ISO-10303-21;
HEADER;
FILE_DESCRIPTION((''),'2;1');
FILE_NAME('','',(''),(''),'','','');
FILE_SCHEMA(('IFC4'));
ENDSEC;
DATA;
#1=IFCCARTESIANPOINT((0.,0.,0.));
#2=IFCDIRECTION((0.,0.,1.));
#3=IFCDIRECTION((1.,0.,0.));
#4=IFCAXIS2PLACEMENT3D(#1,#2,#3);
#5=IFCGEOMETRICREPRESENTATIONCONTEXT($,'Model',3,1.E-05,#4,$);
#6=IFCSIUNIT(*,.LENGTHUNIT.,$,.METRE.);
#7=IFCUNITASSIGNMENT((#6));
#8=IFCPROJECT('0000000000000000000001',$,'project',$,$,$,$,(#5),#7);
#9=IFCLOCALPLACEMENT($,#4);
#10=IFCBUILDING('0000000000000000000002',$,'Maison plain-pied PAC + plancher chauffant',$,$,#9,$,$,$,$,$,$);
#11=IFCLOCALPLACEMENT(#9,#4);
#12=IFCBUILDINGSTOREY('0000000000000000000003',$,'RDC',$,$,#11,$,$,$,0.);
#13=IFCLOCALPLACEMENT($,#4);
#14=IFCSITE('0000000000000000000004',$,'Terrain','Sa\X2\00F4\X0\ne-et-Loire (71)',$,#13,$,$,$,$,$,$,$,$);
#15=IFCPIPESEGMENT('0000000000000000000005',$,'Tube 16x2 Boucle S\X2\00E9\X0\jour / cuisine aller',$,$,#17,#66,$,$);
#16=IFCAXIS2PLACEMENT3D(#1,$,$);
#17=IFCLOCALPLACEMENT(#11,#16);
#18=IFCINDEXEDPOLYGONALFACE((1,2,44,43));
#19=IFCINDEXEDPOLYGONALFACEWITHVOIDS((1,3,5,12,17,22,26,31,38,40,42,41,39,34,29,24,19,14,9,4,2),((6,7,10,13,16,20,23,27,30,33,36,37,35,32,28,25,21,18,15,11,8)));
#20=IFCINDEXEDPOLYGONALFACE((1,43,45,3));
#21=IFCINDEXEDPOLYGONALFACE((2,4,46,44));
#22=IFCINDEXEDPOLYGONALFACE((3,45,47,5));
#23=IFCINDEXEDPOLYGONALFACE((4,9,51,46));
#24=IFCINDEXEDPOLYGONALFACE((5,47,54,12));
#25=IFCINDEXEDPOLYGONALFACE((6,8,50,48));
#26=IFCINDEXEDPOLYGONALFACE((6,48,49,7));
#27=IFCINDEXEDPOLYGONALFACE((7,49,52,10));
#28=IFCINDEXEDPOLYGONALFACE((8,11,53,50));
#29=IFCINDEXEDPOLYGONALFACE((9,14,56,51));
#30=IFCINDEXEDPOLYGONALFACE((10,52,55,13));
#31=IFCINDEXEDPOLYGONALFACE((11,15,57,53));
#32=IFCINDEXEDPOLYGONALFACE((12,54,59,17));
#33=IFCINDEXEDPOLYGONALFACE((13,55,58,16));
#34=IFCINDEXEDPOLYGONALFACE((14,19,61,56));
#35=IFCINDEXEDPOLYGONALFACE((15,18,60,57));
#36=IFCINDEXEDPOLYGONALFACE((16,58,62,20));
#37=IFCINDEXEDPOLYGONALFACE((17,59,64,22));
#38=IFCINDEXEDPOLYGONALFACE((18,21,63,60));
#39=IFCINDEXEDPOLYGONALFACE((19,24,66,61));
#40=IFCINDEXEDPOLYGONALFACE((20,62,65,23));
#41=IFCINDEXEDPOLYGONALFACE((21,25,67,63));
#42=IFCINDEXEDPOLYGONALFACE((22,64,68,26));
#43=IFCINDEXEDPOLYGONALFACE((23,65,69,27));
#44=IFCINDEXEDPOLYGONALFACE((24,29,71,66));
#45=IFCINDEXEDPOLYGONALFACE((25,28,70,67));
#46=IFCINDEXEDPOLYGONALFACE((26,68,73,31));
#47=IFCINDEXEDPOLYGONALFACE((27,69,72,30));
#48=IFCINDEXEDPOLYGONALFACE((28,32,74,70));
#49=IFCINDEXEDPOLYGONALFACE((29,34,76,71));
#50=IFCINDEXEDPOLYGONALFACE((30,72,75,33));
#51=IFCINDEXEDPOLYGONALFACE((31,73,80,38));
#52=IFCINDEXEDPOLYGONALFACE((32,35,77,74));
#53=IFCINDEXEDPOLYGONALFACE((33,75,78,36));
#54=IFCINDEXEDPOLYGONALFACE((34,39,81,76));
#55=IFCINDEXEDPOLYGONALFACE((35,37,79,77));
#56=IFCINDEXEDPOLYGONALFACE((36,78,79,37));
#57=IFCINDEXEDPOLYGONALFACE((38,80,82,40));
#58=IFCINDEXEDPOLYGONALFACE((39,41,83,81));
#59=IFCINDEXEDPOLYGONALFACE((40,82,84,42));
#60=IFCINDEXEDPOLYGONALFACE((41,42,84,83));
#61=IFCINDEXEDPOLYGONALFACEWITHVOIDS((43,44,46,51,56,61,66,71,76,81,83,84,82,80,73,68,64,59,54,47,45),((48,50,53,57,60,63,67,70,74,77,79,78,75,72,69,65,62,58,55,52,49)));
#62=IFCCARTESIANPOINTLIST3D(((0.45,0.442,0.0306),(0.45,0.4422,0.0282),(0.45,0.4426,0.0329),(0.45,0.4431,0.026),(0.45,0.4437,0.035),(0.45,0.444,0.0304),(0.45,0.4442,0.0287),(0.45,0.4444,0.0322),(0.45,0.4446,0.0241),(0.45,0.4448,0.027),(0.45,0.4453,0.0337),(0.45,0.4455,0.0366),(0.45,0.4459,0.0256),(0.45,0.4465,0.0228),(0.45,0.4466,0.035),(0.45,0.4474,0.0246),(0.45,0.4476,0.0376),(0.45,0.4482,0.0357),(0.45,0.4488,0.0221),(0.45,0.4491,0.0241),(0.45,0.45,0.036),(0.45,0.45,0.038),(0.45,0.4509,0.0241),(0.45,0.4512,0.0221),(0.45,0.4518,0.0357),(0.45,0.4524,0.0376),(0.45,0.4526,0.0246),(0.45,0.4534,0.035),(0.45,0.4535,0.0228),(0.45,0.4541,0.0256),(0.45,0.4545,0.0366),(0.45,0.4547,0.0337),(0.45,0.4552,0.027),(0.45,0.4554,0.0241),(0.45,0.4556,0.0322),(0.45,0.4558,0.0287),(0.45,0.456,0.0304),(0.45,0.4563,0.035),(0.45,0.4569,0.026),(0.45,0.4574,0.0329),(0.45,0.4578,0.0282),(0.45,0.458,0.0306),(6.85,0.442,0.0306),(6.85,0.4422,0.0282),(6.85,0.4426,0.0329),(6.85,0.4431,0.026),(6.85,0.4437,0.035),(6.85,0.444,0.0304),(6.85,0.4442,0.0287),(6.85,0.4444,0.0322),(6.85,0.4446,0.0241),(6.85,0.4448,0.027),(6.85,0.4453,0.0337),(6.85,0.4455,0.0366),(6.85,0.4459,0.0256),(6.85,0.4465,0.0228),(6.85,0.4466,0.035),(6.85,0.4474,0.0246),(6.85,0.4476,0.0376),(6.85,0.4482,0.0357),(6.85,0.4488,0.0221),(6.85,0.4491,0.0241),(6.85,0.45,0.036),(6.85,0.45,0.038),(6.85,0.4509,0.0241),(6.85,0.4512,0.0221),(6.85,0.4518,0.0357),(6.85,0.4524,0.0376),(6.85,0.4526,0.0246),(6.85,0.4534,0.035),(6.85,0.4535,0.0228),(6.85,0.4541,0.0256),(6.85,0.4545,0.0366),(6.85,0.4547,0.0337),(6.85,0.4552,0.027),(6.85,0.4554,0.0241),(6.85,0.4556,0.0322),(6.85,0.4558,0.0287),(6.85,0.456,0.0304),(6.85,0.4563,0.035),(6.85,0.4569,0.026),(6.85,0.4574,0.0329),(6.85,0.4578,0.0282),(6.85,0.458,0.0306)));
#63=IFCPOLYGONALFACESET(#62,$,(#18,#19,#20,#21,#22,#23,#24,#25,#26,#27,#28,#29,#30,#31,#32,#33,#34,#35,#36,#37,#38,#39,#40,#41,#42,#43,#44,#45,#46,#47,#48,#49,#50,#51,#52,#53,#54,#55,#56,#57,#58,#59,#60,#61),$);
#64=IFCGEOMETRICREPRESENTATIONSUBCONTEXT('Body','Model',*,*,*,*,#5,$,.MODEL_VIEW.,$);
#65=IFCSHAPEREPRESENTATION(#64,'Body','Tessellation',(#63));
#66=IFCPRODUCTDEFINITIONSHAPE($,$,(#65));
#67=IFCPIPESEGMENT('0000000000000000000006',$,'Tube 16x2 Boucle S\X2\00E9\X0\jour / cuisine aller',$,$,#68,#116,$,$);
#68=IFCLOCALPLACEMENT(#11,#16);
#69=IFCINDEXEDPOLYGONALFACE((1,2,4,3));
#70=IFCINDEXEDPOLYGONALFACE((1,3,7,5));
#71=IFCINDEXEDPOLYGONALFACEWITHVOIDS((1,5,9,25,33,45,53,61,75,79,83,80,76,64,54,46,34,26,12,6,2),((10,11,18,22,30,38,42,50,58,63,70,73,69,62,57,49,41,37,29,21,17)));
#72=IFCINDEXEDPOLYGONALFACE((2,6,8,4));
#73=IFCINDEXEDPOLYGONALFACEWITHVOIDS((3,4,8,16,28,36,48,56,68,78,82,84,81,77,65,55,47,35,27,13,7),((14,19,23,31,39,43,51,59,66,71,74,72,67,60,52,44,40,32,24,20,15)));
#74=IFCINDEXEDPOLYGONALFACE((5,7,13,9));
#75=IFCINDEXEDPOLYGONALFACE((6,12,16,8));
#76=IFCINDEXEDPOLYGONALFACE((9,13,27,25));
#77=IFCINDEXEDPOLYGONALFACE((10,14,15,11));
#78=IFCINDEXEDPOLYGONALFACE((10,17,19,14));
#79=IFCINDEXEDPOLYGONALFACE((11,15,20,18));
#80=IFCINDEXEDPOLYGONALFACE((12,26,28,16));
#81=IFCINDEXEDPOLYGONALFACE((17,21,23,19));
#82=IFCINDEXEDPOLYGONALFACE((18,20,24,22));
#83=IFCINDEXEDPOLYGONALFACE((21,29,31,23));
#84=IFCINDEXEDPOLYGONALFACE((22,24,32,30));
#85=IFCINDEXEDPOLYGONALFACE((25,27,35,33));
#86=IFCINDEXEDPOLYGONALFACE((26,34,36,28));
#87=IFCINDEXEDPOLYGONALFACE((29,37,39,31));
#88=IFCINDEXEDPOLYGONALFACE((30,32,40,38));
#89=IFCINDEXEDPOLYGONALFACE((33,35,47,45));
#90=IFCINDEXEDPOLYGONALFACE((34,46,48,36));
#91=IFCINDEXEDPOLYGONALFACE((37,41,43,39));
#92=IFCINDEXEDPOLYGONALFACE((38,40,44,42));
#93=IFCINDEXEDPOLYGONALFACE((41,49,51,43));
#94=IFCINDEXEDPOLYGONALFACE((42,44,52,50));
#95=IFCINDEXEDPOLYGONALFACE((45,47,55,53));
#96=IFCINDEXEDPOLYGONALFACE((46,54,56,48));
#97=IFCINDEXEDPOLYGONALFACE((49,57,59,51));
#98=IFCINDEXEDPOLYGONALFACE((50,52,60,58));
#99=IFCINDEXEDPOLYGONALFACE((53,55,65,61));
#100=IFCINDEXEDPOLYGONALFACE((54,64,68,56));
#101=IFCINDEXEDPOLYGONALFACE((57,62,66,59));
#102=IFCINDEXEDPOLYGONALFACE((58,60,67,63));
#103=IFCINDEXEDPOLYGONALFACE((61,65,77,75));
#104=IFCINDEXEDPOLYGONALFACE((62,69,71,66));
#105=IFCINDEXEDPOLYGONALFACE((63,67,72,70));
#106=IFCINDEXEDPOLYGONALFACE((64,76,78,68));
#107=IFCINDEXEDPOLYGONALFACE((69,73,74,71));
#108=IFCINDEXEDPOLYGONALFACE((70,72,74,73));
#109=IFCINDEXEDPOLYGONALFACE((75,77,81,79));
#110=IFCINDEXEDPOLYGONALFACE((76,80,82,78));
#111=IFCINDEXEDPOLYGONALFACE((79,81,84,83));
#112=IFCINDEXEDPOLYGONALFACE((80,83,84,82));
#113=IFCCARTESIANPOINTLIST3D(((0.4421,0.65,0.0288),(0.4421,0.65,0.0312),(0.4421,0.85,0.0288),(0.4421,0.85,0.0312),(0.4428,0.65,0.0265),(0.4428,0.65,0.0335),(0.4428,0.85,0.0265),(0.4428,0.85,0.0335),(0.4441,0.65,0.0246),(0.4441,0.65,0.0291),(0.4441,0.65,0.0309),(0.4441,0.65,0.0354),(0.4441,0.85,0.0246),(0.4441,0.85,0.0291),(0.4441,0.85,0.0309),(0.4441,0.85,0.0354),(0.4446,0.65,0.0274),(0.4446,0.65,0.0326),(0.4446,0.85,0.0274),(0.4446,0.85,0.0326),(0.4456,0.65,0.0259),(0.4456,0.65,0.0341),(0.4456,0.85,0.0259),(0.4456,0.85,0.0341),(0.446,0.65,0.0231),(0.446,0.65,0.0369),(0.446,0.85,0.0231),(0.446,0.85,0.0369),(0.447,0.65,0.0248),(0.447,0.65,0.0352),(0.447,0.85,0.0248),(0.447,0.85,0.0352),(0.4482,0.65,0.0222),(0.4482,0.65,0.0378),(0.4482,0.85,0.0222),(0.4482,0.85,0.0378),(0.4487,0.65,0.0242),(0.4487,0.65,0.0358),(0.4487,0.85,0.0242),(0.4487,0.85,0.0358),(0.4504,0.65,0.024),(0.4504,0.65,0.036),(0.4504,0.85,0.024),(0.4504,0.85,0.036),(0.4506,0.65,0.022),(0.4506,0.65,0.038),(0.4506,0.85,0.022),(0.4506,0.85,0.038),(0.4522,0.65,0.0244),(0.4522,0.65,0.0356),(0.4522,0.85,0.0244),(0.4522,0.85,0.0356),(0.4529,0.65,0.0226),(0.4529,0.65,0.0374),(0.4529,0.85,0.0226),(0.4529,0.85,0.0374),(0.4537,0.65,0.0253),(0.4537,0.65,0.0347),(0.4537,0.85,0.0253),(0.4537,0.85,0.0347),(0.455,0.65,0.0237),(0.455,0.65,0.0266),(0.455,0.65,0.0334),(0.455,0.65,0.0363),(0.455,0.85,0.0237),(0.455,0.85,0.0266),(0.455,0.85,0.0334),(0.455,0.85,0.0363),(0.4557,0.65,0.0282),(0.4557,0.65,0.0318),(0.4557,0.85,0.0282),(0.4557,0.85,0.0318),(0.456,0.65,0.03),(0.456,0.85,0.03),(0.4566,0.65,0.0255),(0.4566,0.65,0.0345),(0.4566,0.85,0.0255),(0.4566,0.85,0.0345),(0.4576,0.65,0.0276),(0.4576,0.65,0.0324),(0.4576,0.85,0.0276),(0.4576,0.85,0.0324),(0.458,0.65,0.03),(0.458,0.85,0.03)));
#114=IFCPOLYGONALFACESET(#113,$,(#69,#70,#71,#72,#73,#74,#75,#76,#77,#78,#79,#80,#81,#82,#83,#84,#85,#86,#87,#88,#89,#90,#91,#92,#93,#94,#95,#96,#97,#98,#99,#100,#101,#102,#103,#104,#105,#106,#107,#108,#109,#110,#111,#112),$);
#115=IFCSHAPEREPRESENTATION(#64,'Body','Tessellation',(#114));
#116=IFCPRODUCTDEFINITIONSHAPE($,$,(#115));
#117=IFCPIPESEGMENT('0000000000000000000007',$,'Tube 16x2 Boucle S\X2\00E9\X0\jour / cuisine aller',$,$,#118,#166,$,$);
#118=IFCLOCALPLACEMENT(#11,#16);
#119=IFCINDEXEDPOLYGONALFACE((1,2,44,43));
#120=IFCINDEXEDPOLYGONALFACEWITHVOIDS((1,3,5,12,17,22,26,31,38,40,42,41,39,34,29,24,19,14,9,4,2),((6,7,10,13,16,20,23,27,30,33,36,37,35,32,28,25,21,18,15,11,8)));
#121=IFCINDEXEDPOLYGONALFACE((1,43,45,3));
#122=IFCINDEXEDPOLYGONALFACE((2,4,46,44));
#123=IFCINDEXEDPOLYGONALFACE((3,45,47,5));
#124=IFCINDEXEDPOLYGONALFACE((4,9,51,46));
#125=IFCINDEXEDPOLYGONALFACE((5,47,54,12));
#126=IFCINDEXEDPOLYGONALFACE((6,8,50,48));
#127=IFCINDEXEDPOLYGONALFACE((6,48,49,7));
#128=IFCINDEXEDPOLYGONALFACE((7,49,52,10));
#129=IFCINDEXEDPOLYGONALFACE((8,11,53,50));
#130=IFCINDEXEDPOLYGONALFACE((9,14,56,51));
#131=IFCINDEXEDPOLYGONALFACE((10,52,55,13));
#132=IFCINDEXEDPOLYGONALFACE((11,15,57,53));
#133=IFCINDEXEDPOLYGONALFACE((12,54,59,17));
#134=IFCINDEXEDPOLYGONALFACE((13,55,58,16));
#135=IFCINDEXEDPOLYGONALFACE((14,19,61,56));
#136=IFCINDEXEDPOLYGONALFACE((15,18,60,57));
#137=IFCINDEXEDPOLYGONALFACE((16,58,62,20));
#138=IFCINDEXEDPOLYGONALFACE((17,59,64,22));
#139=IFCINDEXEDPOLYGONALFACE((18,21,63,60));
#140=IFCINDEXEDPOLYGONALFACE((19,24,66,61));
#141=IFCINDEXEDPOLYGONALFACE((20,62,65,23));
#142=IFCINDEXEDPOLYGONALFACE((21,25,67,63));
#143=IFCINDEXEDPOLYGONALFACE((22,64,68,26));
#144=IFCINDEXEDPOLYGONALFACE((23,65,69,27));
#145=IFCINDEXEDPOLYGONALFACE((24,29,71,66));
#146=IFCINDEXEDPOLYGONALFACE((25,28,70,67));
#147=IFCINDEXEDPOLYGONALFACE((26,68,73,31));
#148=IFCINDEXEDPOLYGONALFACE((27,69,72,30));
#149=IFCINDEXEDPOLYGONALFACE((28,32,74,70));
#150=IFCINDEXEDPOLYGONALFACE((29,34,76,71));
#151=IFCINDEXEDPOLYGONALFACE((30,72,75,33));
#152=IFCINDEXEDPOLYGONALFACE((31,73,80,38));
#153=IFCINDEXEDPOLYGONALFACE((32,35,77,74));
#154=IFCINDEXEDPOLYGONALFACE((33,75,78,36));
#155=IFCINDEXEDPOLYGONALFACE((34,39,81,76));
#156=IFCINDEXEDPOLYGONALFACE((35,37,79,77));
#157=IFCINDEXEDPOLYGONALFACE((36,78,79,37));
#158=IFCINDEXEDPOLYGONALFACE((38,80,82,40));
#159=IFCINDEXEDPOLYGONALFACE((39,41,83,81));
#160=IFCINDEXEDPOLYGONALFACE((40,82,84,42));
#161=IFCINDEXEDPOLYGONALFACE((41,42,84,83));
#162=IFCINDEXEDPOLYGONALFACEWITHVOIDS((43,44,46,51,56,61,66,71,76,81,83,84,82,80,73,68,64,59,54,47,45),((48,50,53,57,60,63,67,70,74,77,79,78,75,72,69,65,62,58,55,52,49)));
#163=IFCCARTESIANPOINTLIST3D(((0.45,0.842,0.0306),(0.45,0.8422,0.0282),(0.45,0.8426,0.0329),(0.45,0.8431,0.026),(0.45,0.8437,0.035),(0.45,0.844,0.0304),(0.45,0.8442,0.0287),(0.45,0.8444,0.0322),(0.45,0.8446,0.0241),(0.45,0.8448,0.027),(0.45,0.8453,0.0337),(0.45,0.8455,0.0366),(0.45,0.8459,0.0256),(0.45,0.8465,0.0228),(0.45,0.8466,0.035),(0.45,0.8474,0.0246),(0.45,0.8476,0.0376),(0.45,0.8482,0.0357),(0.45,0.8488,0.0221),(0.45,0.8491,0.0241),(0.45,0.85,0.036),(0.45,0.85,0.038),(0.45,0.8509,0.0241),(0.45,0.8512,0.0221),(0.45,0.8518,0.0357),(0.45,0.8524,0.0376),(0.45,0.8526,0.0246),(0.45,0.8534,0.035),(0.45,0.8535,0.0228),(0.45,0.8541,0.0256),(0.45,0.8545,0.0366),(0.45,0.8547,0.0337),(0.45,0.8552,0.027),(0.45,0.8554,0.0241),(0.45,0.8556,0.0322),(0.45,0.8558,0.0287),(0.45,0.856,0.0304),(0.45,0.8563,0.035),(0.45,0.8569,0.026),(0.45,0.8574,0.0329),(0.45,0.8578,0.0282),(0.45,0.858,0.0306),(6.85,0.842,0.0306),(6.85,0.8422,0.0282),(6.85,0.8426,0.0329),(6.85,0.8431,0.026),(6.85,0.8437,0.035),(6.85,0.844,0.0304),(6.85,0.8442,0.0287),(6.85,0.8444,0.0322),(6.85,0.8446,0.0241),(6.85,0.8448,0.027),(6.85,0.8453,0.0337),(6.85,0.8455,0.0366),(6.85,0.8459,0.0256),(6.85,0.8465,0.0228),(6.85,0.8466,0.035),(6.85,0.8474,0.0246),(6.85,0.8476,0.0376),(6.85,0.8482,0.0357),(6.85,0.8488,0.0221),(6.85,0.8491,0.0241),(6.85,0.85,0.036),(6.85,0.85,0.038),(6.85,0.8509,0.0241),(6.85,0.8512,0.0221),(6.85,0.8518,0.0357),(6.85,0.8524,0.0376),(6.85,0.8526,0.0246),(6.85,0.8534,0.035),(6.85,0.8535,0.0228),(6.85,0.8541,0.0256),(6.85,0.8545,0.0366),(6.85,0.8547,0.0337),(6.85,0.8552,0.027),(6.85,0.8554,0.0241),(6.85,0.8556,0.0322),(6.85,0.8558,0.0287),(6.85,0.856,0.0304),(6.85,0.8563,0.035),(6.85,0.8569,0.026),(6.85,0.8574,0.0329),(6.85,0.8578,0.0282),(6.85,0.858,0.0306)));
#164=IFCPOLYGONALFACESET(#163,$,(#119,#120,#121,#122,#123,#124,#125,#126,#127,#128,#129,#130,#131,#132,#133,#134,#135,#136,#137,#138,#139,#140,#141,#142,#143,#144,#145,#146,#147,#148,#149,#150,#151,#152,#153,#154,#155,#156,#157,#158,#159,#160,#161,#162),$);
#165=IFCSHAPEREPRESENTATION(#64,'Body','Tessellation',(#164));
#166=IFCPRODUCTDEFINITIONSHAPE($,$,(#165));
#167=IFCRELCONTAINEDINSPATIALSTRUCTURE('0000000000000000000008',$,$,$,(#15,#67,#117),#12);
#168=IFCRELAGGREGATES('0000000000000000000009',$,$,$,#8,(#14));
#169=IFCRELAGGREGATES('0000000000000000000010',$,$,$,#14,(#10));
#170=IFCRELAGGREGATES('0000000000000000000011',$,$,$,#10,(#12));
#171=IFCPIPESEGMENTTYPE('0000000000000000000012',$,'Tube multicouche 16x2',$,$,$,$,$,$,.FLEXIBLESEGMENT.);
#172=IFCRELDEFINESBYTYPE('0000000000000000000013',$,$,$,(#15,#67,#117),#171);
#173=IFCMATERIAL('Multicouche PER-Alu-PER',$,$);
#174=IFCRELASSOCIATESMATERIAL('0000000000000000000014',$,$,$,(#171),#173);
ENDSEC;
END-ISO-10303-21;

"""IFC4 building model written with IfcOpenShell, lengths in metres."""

from ifc_helpers import new_model, si_unit, frame, origin_with_axes, place, context, subcontext, project, spatial, hollow_circle, extrude, material, type_object, element, save


model = new_model("IFC4")

# Units and contexts
model_context = context("Model", 3, precision=1e-05, world=origin_with_axes())
body_context = subcontext(model_context, "Body", "Model", "MODEL_VIEW")
ifc_project = project(units=[si_unit("LENGTHUNIT", "METRE")], contexts=[model_context])

# Site, building, storey
site_placement = place(None, origin_with_axes())
site = spatial("IfcSite", under=ifc_project, at=site_placement, Name="Terrain", Description="Saône-et-Loire (71)")
building_placement = place(None, origin_with_axes())
building = spatial("IfcBuilding", under=site, at=building_placement, Name="Maison plain-pied PAC + plancher chauffant")
storey_placement = place(building_placement, origin_with_axes())
storey = spatial("IfcBuildingStorey", under=building, at=storey_placement, Name="RDC", Elevation=0.0)

# Pipe segments
ifc_material_1 = material(Name="Multicouche PER-Alu-PER")
pipe_segment_type = type_object("IfcPipeSegmentType", Name="Tube multicouche 16x2", PredefinedType="FLEXIBLESEGMENT", material=ifc_material_1)
pipe_segment_1_placement = place(storey_placement, frame((0.45, 0.45, 0.03), z_axis=(1.0, 0.0, 0.0), x_axis=(0.0, 0.0, 1.0)))
element("IfcPipeSegment", 1, at=pipe_segment_1_placement, inside=storey, type_object=pipe_segment_type, Name="Tube 16x2 Boucle Séjour / cuisine aller", context=body_context, shape_type="SweptSolid", body=[
    extrude(hollow_circle(Radius=0.008, WallThickness=0.002), origin_with_axes(), (0.0, 0.0, 1.0), 6.4),
])
pipe_segment_2_placement = place(storey_placement, frame((0.45, 0.65, 0.03), z_axis=(0.0, 1.0, 0.0), x_axis=(1.0, 0.0, 0.0)))
element("IfcPipeSegment", 2, at=pipe_segment_2_placement, inside=storey, type_object=pipe_segment_type, Name="Tube 16x2 Boucle Séjour / cuisine aller", context=body_context, shape_type="SweptSolid", body=[
    extrude(hollow_circle(Radius=0.008, WallThickness=0.002), origin_with_axes(), (0.0, 0.0, 1.0), 0.2),
])
pipe_segment_3_placement = place(storey_placement, frame((0.45, 0.85, 0.03), z_axis=(1.0, 0.0, 0.0), x_axis=(0.0, 0.0, 1.0)))
element("IfcPipeSegment", 3, at=pipe_segment_3_placement, inside=storey, type_object=pipe_segment_type, Name="Tube 16x2 Boucle Séjour / cuisine aller", context=body_context, shape_type="SweptSolid", body=[
    extrude(hollow_circle(Radius=0.008, WallThickness=0.002), origin_with_axes(), (0.0, 0.0, 1.0), 6.4),
])

save(model, "model.ifc")
